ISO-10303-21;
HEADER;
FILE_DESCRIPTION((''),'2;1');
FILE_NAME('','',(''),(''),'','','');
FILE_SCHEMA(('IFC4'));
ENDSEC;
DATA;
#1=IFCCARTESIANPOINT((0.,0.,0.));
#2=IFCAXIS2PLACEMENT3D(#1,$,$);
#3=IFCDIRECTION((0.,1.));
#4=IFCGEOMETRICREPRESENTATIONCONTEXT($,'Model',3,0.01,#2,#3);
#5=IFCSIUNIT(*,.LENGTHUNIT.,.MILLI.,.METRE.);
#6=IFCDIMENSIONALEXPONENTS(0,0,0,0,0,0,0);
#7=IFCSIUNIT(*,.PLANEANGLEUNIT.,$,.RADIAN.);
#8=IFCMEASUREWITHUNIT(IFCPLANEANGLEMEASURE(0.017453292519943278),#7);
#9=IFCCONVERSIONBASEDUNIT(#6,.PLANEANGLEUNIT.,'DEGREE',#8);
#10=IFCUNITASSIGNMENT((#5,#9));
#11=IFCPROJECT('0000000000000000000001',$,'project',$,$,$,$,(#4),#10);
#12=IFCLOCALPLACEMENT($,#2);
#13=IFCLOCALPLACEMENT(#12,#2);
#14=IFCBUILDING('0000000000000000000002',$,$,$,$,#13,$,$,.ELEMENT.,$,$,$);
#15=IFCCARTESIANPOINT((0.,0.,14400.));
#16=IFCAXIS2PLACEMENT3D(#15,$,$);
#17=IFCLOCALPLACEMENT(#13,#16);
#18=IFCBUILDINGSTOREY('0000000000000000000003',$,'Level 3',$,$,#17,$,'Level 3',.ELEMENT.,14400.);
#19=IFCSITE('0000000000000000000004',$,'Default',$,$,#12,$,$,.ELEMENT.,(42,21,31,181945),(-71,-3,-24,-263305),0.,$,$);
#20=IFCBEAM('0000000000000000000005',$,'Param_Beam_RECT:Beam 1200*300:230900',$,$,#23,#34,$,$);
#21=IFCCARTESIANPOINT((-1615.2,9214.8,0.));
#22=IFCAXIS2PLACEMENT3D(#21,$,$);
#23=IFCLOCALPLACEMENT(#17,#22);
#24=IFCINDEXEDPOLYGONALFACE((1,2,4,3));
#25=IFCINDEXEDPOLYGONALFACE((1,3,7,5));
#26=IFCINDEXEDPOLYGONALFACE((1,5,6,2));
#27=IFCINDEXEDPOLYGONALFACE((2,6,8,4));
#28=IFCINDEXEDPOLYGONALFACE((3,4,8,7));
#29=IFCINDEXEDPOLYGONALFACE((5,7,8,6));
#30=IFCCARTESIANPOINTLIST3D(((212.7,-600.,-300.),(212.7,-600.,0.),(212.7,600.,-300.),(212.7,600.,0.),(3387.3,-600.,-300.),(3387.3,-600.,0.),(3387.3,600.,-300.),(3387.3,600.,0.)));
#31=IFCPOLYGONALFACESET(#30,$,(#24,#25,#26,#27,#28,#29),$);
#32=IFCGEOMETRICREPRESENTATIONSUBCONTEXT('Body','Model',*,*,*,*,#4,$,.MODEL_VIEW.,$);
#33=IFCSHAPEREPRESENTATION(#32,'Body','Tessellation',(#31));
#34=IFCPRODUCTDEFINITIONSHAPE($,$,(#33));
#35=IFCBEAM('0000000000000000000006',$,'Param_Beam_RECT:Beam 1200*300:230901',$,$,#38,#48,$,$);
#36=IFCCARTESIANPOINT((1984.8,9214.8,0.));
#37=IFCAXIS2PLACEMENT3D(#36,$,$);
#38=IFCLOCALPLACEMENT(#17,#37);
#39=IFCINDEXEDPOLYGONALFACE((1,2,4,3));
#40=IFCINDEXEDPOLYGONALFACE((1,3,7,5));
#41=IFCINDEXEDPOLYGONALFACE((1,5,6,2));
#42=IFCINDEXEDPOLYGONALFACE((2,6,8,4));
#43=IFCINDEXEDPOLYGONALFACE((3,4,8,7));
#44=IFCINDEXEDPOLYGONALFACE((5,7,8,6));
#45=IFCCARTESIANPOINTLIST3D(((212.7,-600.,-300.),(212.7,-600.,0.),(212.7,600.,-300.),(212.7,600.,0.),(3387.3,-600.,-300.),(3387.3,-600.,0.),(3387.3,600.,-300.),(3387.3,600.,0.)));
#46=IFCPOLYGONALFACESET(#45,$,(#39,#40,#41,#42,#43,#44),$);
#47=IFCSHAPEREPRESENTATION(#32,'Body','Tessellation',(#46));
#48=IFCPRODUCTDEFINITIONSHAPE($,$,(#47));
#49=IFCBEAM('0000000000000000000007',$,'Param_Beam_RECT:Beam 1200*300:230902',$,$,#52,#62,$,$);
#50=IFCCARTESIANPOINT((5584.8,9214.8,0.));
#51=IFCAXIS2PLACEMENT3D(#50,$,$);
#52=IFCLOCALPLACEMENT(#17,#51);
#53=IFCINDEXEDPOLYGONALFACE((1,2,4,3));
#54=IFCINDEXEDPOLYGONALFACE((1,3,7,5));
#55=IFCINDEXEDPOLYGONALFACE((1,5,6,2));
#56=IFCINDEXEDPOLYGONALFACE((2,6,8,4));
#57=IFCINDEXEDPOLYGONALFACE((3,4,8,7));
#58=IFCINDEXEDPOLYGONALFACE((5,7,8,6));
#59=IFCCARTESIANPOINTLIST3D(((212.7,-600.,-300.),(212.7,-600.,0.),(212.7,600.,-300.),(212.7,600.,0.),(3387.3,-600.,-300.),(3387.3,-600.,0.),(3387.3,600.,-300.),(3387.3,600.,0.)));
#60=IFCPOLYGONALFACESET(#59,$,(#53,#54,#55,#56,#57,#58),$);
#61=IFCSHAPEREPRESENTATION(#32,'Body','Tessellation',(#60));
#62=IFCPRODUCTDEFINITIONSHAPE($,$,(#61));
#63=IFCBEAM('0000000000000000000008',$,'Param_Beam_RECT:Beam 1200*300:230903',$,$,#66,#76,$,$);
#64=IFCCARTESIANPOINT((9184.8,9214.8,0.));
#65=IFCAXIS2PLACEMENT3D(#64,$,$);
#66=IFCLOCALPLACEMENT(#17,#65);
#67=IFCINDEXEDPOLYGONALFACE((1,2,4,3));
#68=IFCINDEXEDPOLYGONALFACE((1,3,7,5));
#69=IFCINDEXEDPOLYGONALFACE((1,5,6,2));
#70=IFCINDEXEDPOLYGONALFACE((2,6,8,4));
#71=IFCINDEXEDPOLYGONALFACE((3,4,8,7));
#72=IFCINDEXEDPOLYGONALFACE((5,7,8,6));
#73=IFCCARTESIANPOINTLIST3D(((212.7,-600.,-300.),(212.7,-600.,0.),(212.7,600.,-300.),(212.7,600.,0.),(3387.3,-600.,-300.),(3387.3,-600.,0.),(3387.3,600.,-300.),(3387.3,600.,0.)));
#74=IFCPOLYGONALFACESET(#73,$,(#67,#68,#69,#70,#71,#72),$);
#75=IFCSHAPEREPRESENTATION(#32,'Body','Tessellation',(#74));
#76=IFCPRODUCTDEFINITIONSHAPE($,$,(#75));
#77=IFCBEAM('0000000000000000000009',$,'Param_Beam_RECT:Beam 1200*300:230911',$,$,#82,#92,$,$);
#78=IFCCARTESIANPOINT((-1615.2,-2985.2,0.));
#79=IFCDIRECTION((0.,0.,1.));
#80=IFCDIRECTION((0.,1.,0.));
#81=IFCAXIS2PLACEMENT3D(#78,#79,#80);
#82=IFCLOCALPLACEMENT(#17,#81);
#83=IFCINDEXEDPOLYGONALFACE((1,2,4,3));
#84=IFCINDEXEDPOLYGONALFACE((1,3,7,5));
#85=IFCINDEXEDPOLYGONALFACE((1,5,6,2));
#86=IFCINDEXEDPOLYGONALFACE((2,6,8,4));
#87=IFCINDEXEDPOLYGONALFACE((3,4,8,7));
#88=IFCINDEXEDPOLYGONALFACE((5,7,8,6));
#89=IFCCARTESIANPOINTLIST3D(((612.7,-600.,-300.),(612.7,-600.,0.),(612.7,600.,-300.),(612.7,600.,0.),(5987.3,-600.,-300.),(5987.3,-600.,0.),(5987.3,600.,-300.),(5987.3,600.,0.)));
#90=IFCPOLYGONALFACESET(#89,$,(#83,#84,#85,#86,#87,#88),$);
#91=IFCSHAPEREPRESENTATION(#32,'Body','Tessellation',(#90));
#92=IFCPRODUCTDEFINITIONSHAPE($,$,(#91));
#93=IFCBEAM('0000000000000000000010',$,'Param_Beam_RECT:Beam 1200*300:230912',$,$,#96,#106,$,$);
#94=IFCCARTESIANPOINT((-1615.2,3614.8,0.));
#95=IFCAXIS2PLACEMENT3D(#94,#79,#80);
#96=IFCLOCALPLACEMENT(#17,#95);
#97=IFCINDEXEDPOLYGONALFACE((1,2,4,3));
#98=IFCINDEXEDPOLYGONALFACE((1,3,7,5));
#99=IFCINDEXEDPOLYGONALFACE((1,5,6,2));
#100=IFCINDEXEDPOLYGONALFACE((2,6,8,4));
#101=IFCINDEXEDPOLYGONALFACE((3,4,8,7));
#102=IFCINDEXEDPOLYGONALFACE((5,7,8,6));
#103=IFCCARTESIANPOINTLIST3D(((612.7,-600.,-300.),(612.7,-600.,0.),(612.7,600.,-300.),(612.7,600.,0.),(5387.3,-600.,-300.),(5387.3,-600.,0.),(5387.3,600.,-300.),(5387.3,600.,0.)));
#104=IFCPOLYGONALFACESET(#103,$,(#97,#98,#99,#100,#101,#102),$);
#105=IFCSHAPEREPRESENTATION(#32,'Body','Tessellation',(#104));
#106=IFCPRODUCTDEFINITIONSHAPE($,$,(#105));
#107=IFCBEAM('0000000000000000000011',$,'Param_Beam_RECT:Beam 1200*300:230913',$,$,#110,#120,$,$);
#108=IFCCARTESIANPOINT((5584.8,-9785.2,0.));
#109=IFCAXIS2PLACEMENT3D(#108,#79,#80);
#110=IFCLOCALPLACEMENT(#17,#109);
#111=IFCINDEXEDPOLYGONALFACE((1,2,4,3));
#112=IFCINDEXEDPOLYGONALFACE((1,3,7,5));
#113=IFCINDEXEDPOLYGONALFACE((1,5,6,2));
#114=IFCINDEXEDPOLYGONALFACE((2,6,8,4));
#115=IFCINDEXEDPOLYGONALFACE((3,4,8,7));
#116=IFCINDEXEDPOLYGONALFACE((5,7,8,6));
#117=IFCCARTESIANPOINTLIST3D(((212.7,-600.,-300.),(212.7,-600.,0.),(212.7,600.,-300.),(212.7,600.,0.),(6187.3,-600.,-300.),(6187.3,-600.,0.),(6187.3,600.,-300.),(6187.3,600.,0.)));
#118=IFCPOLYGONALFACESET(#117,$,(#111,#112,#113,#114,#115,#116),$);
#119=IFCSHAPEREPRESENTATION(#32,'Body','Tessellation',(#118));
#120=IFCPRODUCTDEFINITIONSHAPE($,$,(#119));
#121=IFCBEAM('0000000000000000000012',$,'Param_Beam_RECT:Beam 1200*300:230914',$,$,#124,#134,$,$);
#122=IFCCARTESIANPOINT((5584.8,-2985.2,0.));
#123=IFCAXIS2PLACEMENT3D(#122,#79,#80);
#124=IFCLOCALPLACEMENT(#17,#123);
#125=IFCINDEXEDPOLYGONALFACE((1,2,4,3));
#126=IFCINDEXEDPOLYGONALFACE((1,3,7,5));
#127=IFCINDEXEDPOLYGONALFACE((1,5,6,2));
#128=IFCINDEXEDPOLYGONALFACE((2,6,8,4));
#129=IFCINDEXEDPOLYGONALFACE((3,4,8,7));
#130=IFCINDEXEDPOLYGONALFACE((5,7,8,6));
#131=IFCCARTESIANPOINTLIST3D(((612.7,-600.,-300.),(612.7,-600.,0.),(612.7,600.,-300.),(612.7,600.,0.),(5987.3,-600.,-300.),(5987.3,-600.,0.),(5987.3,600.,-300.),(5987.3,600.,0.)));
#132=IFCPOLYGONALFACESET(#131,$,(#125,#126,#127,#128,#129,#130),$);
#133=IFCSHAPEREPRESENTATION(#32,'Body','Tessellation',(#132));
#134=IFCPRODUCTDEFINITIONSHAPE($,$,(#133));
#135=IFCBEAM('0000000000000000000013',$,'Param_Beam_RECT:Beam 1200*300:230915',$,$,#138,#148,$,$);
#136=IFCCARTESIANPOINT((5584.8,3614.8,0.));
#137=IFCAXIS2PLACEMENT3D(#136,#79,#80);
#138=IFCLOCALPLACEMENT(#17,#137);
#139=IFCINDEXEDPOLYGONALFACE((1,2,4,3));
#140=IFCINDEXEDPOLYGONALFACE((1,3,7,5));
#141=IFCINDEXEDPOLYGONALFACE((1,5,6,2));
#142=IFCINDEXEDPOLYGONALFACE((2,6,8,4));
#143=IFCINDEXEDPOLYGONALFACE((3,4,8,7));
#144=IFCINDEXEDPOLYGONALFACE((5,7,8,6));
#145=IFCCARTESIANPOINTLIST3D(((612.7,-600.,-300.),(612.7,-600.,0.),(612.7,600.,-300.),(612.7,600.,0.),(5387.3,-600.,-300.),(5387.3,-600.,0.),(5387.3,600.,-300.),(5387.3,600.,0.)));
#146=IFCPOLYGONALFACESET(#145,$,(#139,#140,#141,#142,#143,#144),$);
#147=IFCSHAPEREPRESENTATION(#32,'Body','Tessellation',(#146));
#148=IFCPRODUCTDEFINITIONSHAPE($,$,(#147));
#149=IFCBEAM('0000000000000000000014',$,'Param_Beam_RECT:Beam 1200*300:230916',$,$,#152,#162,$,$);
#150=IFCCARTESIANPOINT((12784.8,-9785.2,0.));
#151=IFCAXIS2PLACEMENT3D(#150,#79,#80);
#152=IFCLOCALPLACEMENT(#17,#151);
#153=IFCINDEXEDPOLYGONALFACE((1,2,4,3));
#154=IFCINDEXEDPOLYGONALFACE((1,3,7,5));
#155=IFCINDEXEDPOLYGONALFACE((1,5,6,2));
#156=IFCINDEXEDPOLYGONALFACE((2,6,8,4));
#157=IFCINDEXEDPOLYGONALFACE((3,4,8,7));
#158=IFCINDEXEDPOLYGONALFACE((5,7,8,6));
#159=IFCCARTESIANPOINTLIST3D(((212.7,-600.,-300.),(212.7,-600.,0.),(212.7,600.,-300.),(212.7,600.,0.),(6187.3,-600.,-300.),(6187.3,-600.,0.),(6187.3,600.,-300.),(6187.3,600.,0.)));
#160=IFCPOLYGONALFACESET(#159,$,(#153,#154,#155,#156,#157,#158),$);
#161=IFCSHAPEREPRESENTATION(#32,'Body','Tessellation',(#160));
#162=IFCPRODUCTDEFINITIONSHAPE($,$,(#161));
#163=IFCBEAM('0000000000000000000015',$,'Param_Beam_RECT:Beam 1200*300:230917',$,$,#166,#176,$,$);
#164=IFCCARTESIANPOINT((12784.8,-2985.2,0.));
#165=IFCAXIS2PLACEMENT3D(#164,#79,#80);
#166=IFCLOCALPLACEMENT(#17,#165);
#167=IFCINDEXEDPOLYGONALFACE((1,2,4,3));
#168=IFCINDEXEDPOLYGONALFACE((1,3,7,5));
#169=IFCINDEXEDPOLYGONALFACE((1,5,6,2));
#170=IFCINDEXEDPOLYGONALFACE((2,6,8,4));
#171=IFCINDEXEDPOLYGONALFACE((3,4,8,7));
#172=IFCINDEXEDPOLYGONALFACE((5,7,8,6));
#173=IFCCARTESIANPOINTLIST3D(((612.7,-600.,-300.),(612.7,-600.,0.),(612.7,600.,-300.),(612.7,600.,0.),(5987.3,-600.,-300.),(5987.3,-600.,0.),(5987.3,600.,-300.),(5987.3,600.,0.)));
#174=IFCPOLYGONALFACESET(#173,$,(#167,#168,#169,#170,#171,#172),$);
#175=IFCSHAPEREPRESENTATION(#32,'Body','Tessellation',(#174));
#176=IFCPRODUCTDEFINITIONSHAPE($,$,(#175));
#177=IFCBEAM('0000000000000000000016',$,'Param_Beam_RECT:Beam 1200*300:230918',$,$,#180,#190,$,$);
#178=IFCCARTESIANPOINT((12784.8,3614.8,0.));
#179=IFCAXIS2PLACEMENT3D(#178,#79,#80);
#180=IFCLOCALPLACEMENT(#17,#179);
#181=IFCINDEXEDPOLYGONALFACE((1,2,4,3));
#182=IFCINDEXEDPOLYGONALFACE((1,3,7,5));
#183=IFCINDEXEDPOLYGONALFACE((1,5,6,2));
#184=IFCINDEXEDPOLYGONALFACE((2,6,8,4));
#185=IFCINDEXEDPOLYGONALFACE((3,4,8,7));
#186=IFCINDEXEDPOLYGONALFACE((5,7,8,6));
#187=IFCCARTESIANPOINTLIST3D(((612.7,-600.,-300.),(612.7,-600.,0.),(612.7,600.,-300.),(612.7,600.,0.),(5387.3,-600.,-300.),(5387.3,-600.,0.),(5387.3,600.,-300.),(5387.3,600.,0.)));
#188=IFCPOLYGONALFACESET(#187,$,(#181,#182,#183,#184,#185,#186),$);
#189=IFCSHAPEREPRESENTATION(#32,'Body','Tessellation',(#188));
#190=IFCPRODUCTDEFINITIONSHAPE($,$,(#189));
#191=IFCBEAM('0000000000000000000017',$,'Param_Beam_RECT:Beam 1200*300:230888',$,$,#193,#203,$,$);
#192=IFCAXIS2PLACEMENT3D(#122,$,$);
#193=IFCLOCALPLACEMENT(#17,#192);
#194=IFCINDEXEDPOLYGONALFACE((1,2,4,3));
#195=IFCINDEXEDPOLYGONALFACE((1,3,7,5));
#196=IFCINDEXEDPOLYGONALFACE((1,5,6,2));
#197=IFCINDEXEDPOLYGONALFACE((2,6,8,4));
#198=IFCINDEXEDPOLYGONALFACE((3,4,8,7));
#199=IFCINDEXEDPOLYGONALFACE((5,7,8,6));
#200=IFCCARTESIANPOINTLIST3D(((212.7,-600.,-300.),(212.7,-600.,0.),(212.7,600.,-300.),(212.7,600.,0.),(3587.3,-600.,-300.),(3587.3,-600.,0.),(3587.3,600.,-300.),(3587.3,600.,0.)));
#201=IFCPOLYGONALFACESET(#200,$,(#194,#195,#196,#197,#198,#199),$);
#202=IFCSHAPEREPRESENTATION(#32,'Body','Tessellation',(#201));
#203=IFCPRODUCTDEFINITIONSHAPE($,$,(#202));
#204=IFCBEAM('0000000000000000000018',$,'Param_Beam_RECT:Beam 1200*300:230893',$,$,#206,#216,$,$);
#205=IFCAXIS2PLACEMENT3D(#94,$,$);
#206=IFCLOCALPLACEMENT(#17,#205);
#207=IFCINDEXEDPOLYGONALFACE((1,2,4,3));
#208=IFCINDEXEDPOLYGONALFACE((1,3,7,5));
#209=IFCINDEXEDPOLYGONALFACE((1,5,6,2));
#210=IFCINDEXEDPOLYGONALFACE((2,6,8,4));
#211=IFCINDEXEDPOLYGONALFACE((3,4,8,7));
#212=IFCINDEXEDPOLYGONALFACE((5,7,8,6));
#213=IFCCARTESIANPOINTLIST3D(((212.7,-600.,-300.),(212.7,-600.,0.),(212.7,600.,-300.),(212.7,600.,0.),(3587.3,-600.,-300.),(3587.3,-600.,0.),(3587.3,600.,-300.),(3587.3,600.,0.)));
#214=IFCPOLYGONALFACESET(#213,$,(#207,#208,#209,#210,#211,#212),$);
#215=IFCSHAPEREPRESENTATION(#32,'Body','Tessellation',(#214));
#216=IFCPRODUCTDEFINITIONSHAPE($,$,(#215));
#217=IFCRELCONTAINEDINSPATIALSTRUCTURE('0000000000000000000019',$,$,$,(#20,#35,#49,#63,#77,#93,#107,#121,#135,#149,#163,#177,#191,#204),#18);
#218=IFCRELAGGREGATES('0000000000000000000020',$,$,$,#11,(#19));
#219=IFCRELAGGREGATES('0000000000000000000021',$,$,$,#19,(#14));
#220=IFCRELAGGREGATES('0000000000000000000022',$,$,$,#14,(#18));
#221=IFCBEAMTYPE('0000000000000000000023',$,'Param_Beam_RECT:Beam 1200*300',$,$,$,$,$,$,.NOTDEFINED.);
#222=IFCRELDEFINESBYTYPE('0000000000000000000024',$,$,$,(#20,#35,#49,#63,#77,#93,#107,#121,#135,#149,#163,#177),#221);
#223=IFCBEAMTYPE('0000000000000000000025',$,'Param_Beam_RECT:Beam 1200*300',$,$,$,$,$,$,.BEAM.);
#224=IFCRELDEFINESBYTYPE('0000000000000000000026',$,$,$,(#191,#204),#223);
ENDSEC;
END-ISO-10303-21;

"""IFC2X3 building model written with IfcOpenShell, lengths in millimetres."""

from ifc_helpers import new_model, entity, si_unit, converted_unit, direction, frame, frame_2d, origin, origin_2d_with_axis, place, context, subcontext, project, spatial, rectangle, extrude, type_object, element, save


model = new_model("IFC2X3")

# Units and contexts
model_context = context("Model", 3, precision=0.01, world=origin(), true_north=direction((0.0, 1.0)))
body_context = subcontext(model_context, "Body", "Model", "MODEL_VIEW")
ifc_project = project(units=[si_unit("LENGTHUNIT", "METRE", prefix="MILLI"), converted_unit("PLANEANGLEUNIT", "DEGREE", entity("IfcPlaneAngleMeasure", 0.017453292519943278), si_unit("PLANEANGLEUNIT", "RADIAN"), dimensions=[0, 0, 0, 0, 0, 0, 0])], contexts=[model_context])

# Site, building, storey
site_placement = place(None, origin())
site = spatial("IfcSite", under=ifc_project, at=site_placement, Name="Default", CompositionType="ELEMENT", RefLatitude=(42, 21, 31, 181945), RefLongitude=(-71, -3, -24, -263305), RefElevation=0.0)
building_placement = place(site_placement, origin())
building = spatial("IfcBuilding", under=site, at=building_placement, CompositionType="ELEMENT")
storey_placement = place(building_placement, frame((0.0, 0.0, 14400.0)))
storey = spatial("IfcBuildingStorey", under=building, at=storey_placement, Name="Level 3", LongName="Level 3", CompositionType="ELEMENT", Elevation=14400.0)

# Beams
beam_type_1 = type_object("IfcBeamType", Name="Param_Beam_RECT:Beam 1200*300", PredefinedType="NOTDEFINED")
beam_1_placement = place(storey_placement, frame((-1615.2, 9214.8, 0.0)))
element("IfcBeam", 1, at=beam_1_placement, inside=storey, type_object=beam_type_1, Name="Param_Beam_RECT:Beam 1200*300:230900", context=body_context, shape_type="SweptSolid", body=[
    extrude(rectangle(XDim=300.0, YDim=1200.0, at=frame_2d((0.0, 0.0), x_axis=(1.0, 0.0))), frame((212.7, 0.0, -150.0), z_axis=(1.0, 0.0, 0.0), x_axis=(0.0, 0.0, -1.0)), (0.0, 0.0, 1.0), 3174.6),
])
beam_2_placement = place(storey_placement, frame((1984.8, 9214.8, 0.0)))
element("IfcBeam", 2, at=beam_2_placement, inside=storey, type_object=beam_type_1, Name="Param_Beam_RECT:Beam 1200*300:230901", context=body_context, shape_type="SweptSolid", body=[
    extrude(rectangle(XDim=300.0, YDim=1200.0, at=origin_2d_with_axis()), frame((212.7, 0.0, -150.0), z_axis=(1.0, 0.0, 0.0), x_axis=(0.0, 0.0, -1.0)), (0.0, 0.0, 1.0), 3174.6),
])
for number, where, name in (
    (3, (5584.8, 9214.8, 0.0), "Param_Beam_RECT:Beam 1200*300:230902"),
    (4, (9184.8, 9214.8, 0.0), "Param_Beam_RECT:Beam 1200*300:230903"),
):
    element("IfcBeam", number, at=place(storey_placement, frame(where)), inside=storey, type_object=beam_type_1, Name=name, context=body_context, shape_type="SweptSolid", body=[
        extrude(rectangle(XDim=300.0, YDim=1200.0, at=frame_2d((0.0, 0.0), x_axis=(1.0, 0.0))), frame((212.7, 0.0, -150.0), z_axis=(1.0, 0.0, 0.0), x_axis=(0.0, 0.0, -1.0)), (0.0, 0.0, 1.0), 3174.6),
    ])
beam_3_placement = place(storey_placement, frame((-1615.2, -2985.2, 0.0), z_axis=(0.0, 0.0, 1.0), x_axis=(0.0, 1.0, 0.0)))
element("IfcBeam", 5, at=beam_3_placement, inside=storey, type_object=beam_type_1, Name="Param_Beam_RECT:Beam 1200*300:230911", context=body_context, shape_type="SweptSolid", body=[
    extrude(rectangle(XDim=300.0, YDim=1200.0, at=frame_2d((0.0, 0.0), x_axis=(1.0, 0.0))), frame((612.7, 0.0, -150.0), z_axis=(1.0, 0.0, 0.0), x_axis=(0.0, 0.0, -1.0)), (0.0, 0.0, 1.0), 5374.6),
])
beam_4_placement = place(storey_placement, frame((-1615.2, 3614.8, 0.0), z_axis=(0.0, 0.0, 1.0), x_axis=(0.0, 1.0, 0.0)))
element("IfcBeam", 6, at=beam_4_placement, inside=storey, type_object=beam_type_1, Name="Param_Beam_RECT:Beam 1200*300:230912", context=body_context, shape_type="SweptSolid", body=[
    extrude(rectangle(XDim=300.0, YDim=1200.0, at=frame_2d((0.0, 0.0), x_axis=(1.0, 0.0))), frame((612.7, 0.0, -150.0), z_axis=(1.0, 0.0, 0.0), x_axis=(0.0, 0.0, -1.0)), (0.0, 0.0, 1.0), 4774.6),
])
beam_5_placement = place(storey_placement, frame((5584.8, -9785.2, 0.0), z_axis=(0.0, 0.0, 1.0), x_axis=(0.0, 1.0, 0.0)))
element("IfcBeam", 7, at=beam_5_placement, inside=storey, type_object=beam_type_1, Name="Param_Beam_RECT:Beam 1200*300:230913", context=body_context, shape_type="SweptSolid", body=[
    extrude(rectangle(XDim=300.0, YDim=1200.0, at=frame_2d((0.0, 0.0), x_axis=(1.0, 0.0))), frame((212.7, 0.0, -150.0), z_axis=(1.0, 0.0, 0.0), x_axis=(0.0, 0.0, -1.0)), (0.0, 0.0, 1.0), 5974.6),
])
beam_6_placement = place(storey_placement, frame((5584.8, -2985.2, 0.0), z_axis=(0.0, 0.0, 1.0), x_axis=(0.0, 1.0, 0.0)))
element("IfcBeam", 8, at=beam_6_placement, inside=storey, type_object=beam_type_1, Name="Param_Beam_RECT:Beam 1200*300:230914", context=body_context, shape_type="SweptSolid", body=[
    extrude(rectangle(XDim=300.0, YDim=1200.0, at=frame_2d((0.0, 0.0), x_axis=(1.0, 0.0))), frame((612.7, 0.0, -150.0), z_axis=(1.0, 0.0, 0.0), x_axis=(0.0, 0.0, -1.0)), (0.0, 0.0, 1.0), 5374.6),
])
beam_7_placement = place(storey_placement, frame((5584.8, 3614.8, 0.0), z_axis=(0.0, 0.0, 1.0), x_axis=(0.0, 1.0, 0.0)))
element("IfcBeam", 9, at=beam_7_placement, inside=storey, type_object=beam_type_1, Name="Param_Beam_RECT:Beam 1200*300:230915", context=body_context, shape_type="SweptSolid", body=[
    extrude(rectangle(XDim=300.0, YDim=1200.0, at=frame_2d((0.0, 0.0), x_axis=(1.0, 0.0))), frame((612.7, 0.0, -150.0), z_axis=(1.0, 0.0, 0.0), x_axis=(0.0, 0.0, -1.0)), (0.0, 0.0, 1.0), 4774.6),
])
beam_8_placement = place(storey_placement, frame((12784.8, -9785.2, 0.0), z_axis=(0.0, 0.0, 1.0), x_axis=(0.0, 1.0, 0.0)))
element("IfcBeam", 10, at=beam_8_placement, inside=storey, type_object=beam_type_1, Name="Param_Beam_RECT:Beam 1200*300:230916", context=body_context, shape_type="SweptSolid", body=[
    extrude(rectangle(XDim=300.0, YDim=1200.0, at=origin_2d_with_axis()), frame((212.7, 0.0, -150.0), z_axis=(1.0, 0.0, 0.0), x_axis=(0.0, 0.0, -1.0)), (0.0, 0.0, 1.0), 5974.6),
])
beam_9_placement = place(storey_placement, frame((12784.8, -2985.2, 0.0), z_axis=(0.0, 0.0, 1.0), x_axis=(0.0, 1.0, 0.0)))
element("IfcBeam", 11, at=beam_9_placement, inside=storey, type_object=beam_type_1, Name="Param_Beam_RECT:Beam 1200*300:230917", context=body_context, shape_type="SweptSolid", body=[
    extrude(rectangle(XDim=300.0, YDim=1200.0, at=frame_2d((0.0, 0.0), x_axis=(1.0, 0.0))), frame((612.7, 0.0, -150.0), z_axis=(1.0, 0.0, 0.0), x_axis=(0.0, 0.0, -1.0)), (0.0, 0.0, 1.0), 5374.6),
])
beam_10_placement = place(storey_placement, frame((12784.8, 3614.8, 0.0), z_axis=(0.0, 0.0, 1.0), x_axis=(0.0, 1.0, 0.0)))
element("IfcBeam", 12, at=beam_10_placement, inside=storey, type_object=beam_type_1, Name="Param_Beam_RECT:Beam 1200*300:230918", context=body_context, shape_type="SweptSolid", body=[
    extrude(rectangle(XDim=300.0, YDim=1200.0, at=origin_2d_with_axis()), frame((612.7, 0.0, -150.0), z_axis=(1.0, 0.0, 0.0), x_axis=(0.0, 0.0, -1.0)), (0.0, 0.0, 1.0), 4774.6),
])
beam_type_2 = type_object("IfcBeamType", Name="Param_Beam_RECT:Beam 1200*300", PredefinedType="BEAM")
beam_11_placement = place(storey_placement, frame((5584.8, -2985.2, 0.0)))
element("IfcBeam", 13, at=beam_11_placement, inside=storey, type_object=beam_type_2, Name="Param_Beam_RECT:Beam 1200*300:230888", context=body_context, shape_type="SweptSolid", body=[
    extrude(rectangle(XDim=300.0, YDim=1200.0, at=frame_2d((0.0, 0.0), x_axis=(1.0, 0.0))), frame((212.7, 0.0, -150.0), z_axis=(1.0, 0.0, 0.0), x_axis=(0.0, 0.0, -1.0)), (0.0, 0.0, 1.0), 3374.6),
])
beam_12_placement = place(storey_placement, frame((-1615.2, 3614.8, 0.0)))
element("IfcBeam", 14, at=beam_12_placement, inside=storey, type_object=beam_type_2, Name="Param_Beam_RECT:Beam 1200*300:230893", context=body_context, shape_type="SweptSolid", body=[
    extrude(rectangle(XDim=300.0, YDim=1200.0, at=frame_2d((0.0, 0.0), x_axis=(1.0, 0.0))), frame((212.7, 0.0, -150.0), z_axis=(1.0, 0.0, 0.0), x_axis=(0.0, 0.0, -1.0)), (0.0, 0.0, 1.0), 3374.6),
])

save(model, "model.ifc")
